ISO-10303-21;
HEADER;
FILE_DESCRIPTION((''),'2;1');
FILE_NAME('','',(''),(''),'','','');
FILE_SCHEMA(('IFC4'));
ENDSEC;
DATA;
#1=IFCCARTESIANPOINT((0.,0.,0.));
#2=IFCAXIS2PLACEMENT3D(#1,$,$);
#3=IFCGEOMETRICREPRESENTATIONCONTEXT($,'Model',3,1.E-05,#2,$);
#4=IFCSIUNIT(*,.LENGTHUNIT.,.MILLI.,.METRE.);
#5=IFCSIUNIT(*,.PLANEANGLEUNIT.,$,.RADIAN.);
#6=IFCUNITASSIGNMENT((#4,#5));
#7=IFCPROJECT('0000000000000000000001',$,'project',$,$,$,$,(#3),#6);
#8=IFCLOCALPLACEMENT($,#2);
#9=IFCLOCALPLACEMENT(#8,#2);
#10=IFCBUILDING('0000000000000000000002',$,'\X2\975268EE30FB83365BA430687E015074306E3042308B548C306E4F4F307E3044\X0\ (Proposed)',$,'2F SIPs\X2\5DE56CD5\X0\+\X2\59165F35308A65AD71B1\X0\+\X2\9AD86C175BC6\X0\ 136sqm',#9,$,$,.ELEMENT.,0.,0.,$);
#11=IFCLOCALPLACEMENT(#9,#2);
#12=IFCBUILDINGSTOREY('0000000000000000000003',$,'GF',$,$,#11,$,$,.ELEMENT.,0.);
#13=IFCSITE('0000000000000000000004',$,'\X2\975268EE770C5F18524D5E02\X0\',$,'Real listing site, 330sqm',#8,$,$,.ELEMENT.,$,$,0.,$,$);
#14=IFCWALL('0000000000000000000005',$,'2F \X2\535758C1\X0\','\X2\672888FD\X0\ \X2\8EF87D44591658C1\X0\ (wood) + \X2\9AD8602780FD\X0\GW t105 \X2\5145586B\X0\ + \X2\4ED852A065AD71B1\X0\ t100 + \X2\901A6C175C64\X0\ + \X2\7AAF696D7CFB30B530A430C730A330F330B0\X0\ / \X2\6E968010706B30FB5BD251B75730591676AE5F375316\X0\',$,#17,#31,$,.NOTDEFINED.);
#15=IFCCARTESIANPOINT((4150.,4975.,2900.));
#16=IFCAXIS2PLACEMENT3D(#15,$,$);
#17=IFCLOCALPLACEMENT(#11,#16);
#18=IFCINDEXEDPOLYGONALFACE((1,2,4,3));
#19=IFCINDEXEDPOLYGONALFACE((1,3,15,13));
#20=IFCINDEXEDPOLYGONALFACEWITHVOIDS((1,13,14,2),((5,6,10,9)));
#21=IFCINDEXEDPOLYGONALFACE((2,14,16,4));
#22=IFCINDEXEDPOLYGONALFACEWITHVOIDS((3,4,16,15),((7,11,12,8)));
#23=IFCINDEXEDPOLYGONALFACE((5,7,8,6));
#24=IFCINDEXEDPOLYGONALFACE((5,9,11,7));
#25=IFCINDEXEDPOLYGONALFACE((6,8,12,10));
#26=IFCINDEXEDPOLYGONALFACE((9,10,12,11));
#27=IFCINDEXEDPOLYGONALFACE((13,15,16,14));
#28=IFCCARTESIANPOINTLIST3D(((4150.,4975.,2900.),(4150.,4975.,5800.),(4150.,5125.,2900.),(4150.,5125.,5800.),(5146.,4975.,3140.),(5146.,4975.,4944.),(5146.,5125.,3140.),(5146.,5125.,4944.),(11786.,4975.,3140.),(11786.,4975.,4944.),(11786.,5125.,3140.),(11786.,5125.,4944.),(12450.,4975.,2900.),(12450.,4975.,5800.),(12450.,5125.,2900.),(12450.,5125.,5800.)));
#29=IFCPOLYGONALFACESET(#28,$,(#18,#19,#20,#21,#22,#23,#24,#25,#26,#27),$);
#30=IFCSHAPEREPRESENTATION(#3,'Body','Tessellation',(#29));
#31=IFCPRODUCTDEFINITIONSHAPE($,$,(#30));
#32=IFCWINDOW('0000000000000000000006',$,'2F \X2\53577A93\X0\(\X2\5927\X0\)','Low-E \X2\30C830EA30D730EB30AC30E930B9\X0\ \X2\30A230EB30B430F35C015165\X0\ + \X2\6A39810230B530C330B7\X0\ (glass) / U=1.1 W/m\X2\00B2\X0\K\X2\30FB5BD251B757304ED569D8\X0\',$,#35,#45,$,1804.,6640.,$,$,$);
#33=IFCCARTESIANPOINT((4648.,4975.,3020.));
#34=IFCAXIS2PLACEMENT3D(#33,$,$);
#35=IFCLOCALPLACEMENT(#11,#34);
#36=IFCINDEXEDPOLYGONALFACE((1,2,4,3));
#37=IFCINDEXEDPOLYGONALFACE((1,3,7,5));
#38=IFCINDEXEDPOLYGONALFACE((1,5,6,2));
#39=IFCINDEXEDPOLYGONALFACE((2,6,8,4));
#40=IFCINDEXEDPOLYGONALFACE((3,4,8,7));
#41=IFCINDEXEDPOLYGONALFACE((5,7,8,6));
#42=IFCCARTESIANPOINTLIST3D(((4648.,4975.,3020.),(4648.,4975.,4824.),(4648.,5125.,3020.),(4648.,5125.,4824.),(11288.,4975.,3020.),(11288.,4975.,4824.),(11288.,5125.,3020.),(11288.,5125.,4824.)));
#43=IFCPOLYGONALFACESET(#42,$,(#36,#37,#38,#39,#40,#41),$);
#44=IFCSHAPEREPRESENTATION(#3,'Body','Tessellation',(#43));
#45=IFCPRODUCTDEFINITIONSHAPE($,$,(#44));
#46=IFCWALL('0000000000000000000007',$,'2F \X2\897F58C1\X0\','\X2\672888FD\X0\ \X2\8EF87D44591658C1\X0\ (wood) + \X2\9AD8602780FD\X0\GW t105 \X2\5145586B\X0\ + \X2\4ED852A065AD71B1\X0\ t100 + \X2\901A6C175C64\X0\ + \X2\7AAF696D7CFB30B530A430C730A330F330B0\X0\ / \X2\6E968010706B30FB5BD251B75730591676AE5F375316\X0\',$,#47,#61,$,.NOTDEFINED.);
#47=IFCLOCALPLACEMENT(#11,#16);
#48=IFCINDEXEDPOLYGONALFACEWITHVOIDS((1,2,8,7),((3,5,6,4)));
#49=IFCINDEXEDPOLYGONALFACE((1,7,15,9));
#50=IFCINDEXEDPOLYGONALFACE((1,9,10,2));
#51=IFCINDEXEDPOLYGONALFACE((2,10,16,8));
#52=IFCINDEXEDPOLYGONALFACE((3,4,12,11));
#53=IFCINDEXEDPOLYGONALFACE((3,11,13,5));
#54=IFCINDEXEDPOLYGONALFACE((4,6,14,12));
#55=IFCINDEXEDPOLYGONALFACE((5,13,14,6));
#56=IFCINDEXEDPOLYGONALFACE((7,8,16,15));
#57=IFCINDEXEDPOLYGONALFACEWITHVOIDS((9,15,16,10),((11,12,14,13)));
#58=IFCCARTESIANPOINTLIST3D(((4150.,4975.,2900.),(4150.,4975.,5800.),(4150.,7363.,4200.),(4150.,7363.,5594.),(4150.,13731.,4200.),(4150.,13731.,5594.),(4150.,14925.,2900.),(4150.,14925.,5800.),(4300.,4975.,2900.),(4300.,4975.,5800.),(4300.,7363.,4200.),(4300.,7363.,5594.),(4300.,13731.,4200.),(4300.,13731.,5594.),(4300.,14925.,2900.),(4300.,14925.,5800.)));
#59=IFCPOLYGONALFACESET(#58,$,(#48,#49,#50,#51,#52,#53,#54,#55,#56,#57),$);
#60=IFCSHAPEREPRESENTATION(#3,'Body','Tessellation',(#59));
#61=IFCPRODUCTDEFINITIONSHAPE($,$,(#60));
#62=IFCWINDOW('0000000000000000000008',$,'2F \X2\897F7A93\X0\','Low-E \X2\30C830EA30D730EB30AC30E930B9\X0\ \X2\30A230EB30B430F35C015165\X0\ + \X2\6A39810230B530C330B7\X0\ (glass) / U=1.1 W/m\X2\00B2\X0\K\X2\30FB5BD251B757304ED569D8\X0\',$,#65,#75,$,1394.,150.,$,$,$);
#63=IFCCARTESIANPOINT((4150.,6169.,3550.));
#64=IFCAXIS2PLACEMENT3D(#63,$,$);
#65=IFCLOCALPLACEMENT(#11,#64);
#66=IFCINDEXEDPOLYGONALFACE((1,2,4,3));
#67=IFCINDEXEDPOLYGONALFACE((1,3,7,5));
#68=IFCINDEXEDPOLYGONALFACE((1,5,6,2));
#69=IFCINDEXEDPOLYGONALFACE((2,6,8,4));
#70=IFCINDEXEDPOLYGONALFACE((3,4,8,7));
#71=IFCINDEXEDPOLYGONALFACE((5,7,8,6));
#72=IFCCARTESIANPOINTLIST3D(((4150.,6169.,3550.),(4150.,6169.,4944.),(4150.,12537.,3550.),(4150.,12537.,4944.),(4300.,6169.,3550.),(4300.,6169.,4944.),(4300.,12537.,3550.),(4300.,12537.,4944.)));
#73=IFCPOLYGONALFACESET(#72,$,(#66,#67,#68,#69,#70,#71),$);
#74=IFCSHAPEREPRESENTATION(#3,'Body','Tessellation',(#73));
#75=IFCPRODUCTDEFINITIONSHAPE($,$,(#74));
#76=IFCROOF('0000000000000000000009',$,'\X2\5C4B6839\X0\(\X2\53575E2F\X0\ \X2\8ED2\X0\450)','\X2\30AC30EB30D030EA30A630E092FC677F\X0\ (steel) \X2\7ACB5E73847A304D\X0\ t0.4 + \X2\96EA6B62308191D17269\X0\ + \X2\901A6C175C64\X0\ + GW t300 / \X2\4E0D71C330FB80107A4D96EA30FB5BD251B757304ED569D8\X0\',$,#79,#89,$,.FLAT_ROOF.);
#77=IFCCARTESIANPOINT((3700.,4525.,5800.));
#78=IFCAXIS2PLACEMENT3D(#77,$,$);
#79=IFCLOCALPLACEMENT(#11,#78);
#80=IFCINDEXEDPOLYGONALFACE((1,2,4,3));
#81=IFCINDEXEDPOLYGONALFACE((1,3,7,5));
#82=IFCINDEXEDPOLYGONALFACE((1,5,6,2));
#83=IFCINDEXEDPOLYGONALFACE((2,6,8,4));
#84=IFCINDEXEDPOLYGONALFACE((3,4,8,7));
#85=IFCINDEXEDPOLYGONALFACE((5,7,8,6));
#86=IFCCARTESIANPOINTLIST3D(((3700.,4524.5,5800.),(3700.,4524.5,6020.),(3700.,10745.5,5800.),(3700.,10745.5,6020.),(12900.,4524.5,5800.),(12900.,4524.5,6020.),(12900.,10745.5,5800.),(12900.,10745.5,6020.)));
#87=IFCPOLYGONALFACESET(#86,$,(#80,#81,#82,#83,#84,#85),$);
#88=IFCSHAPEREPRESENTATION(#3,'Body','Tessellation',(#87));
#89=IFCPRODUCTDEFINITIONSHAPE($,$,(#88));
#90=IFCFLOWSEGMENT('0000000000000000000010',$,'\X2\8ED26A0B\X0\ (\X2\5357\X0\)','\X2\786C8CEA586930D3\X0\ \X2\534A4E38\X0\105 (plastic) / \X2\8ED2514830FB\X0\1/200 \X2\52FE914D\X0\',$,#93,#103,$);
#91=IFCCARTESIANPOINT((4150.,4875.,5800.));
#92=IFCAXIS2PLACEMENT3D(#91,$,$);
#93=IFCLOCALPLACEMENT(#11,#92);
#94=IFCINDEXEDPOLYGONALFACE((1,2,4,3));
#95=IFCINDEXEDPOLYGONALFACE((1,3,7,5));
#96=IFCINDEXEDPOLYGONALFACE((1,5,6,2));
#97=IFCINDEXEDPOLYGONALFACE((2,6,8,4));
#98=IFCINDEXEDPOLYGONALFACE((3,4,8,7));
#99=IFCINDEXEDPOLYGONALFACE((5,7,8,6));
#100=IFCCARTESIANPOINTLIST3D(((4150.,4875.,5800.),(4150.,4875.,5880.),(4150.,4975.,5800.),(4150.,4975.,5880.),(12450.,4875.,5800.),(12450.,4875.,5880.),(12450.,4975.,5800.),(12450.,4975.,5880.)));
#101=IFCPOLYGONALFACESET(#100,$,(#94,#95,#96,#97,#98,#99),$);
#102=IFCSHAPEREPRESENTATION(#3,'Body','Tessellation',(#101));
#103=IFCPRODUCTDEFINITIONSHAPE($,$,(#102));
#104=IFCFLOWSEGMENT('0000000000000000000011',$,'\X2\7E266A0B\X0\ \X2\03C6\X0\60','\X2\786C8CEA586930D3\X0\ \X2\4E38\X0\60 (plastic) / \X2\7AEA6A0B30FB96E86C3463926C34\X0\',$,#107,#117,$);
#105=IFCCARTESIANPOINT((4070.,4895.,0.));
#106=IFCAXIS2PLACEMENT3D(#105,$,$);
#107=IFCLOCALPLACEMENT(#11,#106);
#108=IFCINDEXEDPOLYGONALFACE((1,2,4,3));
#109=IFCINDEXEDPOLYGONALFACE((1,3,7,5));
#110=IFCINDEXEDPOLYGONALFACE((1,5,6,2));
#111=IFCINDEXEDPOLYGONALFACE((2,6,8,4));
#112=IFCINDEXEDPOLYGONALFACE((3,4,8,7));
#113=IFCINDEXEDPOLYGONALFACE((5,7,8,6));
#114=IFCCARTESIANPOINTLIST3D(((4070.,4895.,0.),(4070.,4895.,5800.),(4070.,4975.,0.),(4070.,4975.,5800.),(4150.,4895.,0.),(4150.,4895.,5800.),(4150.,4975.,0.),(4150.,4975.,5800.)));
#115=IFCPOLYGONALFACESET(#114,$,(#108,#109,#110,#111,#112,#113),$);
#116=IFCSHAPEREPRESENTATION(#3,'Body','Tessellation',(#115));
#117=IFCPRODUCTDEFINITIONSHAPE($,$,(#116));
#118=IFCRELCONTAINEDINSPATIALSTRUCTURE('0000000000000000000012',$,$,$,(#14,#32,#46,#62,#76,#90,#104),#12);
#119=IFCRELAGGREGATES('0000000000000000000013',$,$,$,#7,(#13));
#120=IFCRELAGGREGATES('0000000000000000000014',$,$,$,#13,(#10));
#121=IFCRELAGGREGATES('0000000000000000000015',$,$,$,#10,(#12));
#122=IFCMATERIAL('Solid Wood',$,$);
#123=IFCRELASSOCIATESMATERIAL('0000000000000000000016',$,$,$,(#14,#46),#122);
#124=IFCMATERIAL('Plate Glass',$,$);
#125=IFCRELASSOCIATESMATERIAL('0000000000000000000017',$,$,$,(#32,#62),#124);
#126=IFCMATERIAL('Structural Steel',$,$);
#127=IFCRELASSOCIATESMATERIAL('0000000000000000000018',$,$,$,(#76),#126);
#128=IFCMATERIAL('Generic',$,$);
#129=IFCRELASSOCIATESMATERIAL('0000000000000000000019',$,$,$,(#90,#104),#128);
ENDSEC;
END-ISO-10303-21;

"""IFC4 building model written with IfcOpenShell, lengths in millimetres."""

from ifc_helpers import new_model, si_unit, frame, frame_2d, origin, place, context, project, spatial, rectangle, extrude, material, element, fill, save


model = new_model("IFC4")

# Units and contexts
model_context = context("Model", 3, precision=1e-05, world=origin())
ifc_project = project(units=[si_unit("LENGTHUNIT", "METRE", prefix="MILLI"), si_unit("PLANEANGLEUNIT", "RADIAN")], contexts=[model_context])

# Site, building, storey
site_placement = place(None, origin())
site = spatial("IfcSite", under=ifc_project, at=site_placement, Name="青森県弘前市", ObjectType="Real listing site, 330sqm", CompositionType="ELEMENT", RefElevation=0.0)
building_placement = place(site_placement, origin())
building = spatial("IfcBuilding", under=site, at=building_placement, Name="青森・茶室と縁側のある和の住まい (Proposed)", ObjectType="2F SIPs工法+外張り断熱+高気密 136sqm", CompositionType="ELEMENT", ElevationOfRefHeight=0.0, ElevationOfTerrain=0.0)
storey_placement = place(building_placement, origin())
storey = spatial("IfcBuildingStorey", under=building, at=storey_placement, Name="GF", CompositionType="ELEMENT", Elevation=0.0)

# Shared definitions
ifc_material_1 = material(Name="Solid Wood")

# Shared definitions
ifc_material_2 = material(Name="Plate Glass")

# Walls, openings, windows
wall_1_placement = place(storey_placement, frame((4150.0, 4975.0, 2900.0)))
wall_1 = element("IfcWall", 1, at=wall_1_placement, inside=storey, material=ifc_material_1, Name="2F 南壁", Description="木製 軸組外壁 (wood) + 高性能GW t105 充填 + 付加断熱 t100 + 通気層 + 窯業系サイディング / 準耐火・寒冷地外皮強化", PredefinedType="NOTDEFINED", context=model_context, shape_type="SweptSolid", body=[
    extrude(rectangle(XDim=8300.0, YDim=150.0, at=frame_2d((4150.0, 75.0))), frame((4150.0, 4975.0, 2900.0)), (0.0, 0.0, 1.0), 2900.0),
])
opening_1_placement = place(storey_placement, frame((4648.0, 4975.0, 3020.0)))
opening_1 = element("IfcOpeningElement", 2, at=opening_1_placement, cuts=wall_1, PredefinedType="NOTDEFINED", context=model_context, shape_type="SweptSolid", body=[
    extrude(rectangle(XDim=6640.0, YDim=150.0, at=frame_2d((3320.0, 75.0))), frame((4648.0, 4975.0, 3020.0)), (0.0, 0.0, 1.0), 1804.0),
])
window_1_placement = place(storey_placement, frame((4648.0, 4975.0, 3020.0)))
window_1 = element("IfcWindow", 3, at=window_1_placement, inside=storey, material=ifc_material_2, Name="2F 南窓(大)", Description="Low-E トリプルガラス アルゴン封入 + 樹脂サッシ (glass) / U=1.1 W/m²K・寒冷地仕様", OverallHeight=1804.0, OverallWidth=6640.0, context=model_context, shape_type="SweptSolid", body=[
    extrude(rectangle(XDim=6640.0, YDim=150.0, at=frame_2d((3320.0, 75.0))), frame((4648.0, 4975.0, 3020.0)), (0.0, 0.0, 1.0), 1804.0),
])
fill(opening_1, window_1)
wall_2_placement = place(storey_placement, frame((4150.0, 4975.0, 2900.0)))
wall_2 = element("IfcWall", 4, at=wall_2_placement, inside=storey, material=ifc_material_1, Name="2F 西壁", Description="木製 軸組外壁 (wood) + 高性能GW t105 充填 + 付加断熱 t100 + 通気層 + 窯業系サイディング / 準耐火・寒冷地外皮強化", PredefinedType="NOTDEFINED", context=model_context, shape_type="SweptSolid", body=[
    extrude(rectangle(XDim=150.0, YDim=9950.0, at=frame_2d((75.0, 4975.0))), frame((4150.0, 4975.0, 2900.0)), (0.0, 0.0, 1.0), 2900.0),
])
opening_2_placement = place(storey_placement, frame((4150.0, 6169.0, 3550.0)))
opening_2 = element("IfcOpeningElement", 5, at=opening_2_placement, cuts=wall_2, PredefinedType="NOTDEFINED", context=model_context, shape_type="SweptSolid", body=[
    extrude(rectangle(XDim=150.0, YDim=6368.0, at=frame_2d((75.0, 3184.0))), frame((4150.0, 6169.0, 3550.0)), (0.0, 0.0, 1.0), 1394.0),
])
window_2_placement = place(storey_placement, frame((4150.0, 6169.0, 3550.0)))
window_2 = element("IfcWindow", 6, at=window_2_placement, inside=storey, material=ifc_material_2, Name="2F 西窓", Description="Low-E トリプルガラス アルゴン封入 + 樹脂サッシ (glass) / U=1.1 W/m²K・寒冷地仕様", OverallHeight=1394.0, OverallWidth=150.0, context=model_context, shape_type="SweptSolid", body=[
    extrude(rectangle(XDim=150.0, YDim=6368.0, at=frame_2d((75.0, 3184.0))), frame((4150.0, 6169.0, 3550.0)), (0.0, 0.0, 1.0), 1394.0),
])
fill(opening_2, window_2)

# Roof
ifc_material_3 = material(Name="Structural Steel")
for number, where, name in (
    (7, (3700.0, 4525.0, 5800.0), "屋根(南帯 軒450)"),
):
    element("IfcRoof", number, at=place(storey_placement, frame(where)), inside=storey, material=ifc_material_3, Name=name, Description="ガルバリウム鋼板 (steel) 立平葺き t0.4 + 雪止め金物 + 通気層 + GW t300 / 不燃・耐積雪・寒冷地仕様", PredefinedType="FLAT_ROOF", context=model_context, shape_type="SweptSolid", body=[
        extrude(rectangle(XDim=9200.0, YDim=6221.0, at=frame_2d((4600.0, 3110.0))), frame((3700.0, 4525.0, 5800.0)), (0.0, 0.0, 1.0), 220.0),
    ])

# Flow segments
ifc_material_4 = material(Name="Generic")
flow_segment_1_placement = place(storey_placement, frame((4150.0, 4875.0, 5800.0)))
element("IfcFlowSegment", 8, at=flow_segment_1_placement, inside=storey, material=ifc_material_4, Name="軒樋 (南)", Description="硬質塩ビ 半丸105 (plastic) / 軒先・1/200 勾配", context=model_context, shape_type="SweptSolid", body=[
    extrude(rectangle(XDim=8300.0, YDim=100.0, at=frame_2d((4150.0, 50.0))), frame((4150.0, 4875.0, 5800.0)), (0.0, 0.0, 1.0), 80.0),
])
flow_segment_2_placement = place(storey_placement, frame((4070.0, 4895.0, 0.0)))
element("IfcFlowSegment", 9, at=flow_segment_2_placement, inside=storey, material=ifc_material_4, Name="縦樋 φ60", Description="硬質塩ビ 丸60 (plastic) / 竪樋・雨水排水", context=model_context, shape_type="SweptSolid", body=[
    extrude(rectangle(XDim=80.0, YDim=80.0, at=frame_2d((40.0, 40.0))), frame((4070.0, 4895.0, 0.0)), (0.0, 0.0, 1.0), 5800.0),
])

save(model, "model.ifc")
